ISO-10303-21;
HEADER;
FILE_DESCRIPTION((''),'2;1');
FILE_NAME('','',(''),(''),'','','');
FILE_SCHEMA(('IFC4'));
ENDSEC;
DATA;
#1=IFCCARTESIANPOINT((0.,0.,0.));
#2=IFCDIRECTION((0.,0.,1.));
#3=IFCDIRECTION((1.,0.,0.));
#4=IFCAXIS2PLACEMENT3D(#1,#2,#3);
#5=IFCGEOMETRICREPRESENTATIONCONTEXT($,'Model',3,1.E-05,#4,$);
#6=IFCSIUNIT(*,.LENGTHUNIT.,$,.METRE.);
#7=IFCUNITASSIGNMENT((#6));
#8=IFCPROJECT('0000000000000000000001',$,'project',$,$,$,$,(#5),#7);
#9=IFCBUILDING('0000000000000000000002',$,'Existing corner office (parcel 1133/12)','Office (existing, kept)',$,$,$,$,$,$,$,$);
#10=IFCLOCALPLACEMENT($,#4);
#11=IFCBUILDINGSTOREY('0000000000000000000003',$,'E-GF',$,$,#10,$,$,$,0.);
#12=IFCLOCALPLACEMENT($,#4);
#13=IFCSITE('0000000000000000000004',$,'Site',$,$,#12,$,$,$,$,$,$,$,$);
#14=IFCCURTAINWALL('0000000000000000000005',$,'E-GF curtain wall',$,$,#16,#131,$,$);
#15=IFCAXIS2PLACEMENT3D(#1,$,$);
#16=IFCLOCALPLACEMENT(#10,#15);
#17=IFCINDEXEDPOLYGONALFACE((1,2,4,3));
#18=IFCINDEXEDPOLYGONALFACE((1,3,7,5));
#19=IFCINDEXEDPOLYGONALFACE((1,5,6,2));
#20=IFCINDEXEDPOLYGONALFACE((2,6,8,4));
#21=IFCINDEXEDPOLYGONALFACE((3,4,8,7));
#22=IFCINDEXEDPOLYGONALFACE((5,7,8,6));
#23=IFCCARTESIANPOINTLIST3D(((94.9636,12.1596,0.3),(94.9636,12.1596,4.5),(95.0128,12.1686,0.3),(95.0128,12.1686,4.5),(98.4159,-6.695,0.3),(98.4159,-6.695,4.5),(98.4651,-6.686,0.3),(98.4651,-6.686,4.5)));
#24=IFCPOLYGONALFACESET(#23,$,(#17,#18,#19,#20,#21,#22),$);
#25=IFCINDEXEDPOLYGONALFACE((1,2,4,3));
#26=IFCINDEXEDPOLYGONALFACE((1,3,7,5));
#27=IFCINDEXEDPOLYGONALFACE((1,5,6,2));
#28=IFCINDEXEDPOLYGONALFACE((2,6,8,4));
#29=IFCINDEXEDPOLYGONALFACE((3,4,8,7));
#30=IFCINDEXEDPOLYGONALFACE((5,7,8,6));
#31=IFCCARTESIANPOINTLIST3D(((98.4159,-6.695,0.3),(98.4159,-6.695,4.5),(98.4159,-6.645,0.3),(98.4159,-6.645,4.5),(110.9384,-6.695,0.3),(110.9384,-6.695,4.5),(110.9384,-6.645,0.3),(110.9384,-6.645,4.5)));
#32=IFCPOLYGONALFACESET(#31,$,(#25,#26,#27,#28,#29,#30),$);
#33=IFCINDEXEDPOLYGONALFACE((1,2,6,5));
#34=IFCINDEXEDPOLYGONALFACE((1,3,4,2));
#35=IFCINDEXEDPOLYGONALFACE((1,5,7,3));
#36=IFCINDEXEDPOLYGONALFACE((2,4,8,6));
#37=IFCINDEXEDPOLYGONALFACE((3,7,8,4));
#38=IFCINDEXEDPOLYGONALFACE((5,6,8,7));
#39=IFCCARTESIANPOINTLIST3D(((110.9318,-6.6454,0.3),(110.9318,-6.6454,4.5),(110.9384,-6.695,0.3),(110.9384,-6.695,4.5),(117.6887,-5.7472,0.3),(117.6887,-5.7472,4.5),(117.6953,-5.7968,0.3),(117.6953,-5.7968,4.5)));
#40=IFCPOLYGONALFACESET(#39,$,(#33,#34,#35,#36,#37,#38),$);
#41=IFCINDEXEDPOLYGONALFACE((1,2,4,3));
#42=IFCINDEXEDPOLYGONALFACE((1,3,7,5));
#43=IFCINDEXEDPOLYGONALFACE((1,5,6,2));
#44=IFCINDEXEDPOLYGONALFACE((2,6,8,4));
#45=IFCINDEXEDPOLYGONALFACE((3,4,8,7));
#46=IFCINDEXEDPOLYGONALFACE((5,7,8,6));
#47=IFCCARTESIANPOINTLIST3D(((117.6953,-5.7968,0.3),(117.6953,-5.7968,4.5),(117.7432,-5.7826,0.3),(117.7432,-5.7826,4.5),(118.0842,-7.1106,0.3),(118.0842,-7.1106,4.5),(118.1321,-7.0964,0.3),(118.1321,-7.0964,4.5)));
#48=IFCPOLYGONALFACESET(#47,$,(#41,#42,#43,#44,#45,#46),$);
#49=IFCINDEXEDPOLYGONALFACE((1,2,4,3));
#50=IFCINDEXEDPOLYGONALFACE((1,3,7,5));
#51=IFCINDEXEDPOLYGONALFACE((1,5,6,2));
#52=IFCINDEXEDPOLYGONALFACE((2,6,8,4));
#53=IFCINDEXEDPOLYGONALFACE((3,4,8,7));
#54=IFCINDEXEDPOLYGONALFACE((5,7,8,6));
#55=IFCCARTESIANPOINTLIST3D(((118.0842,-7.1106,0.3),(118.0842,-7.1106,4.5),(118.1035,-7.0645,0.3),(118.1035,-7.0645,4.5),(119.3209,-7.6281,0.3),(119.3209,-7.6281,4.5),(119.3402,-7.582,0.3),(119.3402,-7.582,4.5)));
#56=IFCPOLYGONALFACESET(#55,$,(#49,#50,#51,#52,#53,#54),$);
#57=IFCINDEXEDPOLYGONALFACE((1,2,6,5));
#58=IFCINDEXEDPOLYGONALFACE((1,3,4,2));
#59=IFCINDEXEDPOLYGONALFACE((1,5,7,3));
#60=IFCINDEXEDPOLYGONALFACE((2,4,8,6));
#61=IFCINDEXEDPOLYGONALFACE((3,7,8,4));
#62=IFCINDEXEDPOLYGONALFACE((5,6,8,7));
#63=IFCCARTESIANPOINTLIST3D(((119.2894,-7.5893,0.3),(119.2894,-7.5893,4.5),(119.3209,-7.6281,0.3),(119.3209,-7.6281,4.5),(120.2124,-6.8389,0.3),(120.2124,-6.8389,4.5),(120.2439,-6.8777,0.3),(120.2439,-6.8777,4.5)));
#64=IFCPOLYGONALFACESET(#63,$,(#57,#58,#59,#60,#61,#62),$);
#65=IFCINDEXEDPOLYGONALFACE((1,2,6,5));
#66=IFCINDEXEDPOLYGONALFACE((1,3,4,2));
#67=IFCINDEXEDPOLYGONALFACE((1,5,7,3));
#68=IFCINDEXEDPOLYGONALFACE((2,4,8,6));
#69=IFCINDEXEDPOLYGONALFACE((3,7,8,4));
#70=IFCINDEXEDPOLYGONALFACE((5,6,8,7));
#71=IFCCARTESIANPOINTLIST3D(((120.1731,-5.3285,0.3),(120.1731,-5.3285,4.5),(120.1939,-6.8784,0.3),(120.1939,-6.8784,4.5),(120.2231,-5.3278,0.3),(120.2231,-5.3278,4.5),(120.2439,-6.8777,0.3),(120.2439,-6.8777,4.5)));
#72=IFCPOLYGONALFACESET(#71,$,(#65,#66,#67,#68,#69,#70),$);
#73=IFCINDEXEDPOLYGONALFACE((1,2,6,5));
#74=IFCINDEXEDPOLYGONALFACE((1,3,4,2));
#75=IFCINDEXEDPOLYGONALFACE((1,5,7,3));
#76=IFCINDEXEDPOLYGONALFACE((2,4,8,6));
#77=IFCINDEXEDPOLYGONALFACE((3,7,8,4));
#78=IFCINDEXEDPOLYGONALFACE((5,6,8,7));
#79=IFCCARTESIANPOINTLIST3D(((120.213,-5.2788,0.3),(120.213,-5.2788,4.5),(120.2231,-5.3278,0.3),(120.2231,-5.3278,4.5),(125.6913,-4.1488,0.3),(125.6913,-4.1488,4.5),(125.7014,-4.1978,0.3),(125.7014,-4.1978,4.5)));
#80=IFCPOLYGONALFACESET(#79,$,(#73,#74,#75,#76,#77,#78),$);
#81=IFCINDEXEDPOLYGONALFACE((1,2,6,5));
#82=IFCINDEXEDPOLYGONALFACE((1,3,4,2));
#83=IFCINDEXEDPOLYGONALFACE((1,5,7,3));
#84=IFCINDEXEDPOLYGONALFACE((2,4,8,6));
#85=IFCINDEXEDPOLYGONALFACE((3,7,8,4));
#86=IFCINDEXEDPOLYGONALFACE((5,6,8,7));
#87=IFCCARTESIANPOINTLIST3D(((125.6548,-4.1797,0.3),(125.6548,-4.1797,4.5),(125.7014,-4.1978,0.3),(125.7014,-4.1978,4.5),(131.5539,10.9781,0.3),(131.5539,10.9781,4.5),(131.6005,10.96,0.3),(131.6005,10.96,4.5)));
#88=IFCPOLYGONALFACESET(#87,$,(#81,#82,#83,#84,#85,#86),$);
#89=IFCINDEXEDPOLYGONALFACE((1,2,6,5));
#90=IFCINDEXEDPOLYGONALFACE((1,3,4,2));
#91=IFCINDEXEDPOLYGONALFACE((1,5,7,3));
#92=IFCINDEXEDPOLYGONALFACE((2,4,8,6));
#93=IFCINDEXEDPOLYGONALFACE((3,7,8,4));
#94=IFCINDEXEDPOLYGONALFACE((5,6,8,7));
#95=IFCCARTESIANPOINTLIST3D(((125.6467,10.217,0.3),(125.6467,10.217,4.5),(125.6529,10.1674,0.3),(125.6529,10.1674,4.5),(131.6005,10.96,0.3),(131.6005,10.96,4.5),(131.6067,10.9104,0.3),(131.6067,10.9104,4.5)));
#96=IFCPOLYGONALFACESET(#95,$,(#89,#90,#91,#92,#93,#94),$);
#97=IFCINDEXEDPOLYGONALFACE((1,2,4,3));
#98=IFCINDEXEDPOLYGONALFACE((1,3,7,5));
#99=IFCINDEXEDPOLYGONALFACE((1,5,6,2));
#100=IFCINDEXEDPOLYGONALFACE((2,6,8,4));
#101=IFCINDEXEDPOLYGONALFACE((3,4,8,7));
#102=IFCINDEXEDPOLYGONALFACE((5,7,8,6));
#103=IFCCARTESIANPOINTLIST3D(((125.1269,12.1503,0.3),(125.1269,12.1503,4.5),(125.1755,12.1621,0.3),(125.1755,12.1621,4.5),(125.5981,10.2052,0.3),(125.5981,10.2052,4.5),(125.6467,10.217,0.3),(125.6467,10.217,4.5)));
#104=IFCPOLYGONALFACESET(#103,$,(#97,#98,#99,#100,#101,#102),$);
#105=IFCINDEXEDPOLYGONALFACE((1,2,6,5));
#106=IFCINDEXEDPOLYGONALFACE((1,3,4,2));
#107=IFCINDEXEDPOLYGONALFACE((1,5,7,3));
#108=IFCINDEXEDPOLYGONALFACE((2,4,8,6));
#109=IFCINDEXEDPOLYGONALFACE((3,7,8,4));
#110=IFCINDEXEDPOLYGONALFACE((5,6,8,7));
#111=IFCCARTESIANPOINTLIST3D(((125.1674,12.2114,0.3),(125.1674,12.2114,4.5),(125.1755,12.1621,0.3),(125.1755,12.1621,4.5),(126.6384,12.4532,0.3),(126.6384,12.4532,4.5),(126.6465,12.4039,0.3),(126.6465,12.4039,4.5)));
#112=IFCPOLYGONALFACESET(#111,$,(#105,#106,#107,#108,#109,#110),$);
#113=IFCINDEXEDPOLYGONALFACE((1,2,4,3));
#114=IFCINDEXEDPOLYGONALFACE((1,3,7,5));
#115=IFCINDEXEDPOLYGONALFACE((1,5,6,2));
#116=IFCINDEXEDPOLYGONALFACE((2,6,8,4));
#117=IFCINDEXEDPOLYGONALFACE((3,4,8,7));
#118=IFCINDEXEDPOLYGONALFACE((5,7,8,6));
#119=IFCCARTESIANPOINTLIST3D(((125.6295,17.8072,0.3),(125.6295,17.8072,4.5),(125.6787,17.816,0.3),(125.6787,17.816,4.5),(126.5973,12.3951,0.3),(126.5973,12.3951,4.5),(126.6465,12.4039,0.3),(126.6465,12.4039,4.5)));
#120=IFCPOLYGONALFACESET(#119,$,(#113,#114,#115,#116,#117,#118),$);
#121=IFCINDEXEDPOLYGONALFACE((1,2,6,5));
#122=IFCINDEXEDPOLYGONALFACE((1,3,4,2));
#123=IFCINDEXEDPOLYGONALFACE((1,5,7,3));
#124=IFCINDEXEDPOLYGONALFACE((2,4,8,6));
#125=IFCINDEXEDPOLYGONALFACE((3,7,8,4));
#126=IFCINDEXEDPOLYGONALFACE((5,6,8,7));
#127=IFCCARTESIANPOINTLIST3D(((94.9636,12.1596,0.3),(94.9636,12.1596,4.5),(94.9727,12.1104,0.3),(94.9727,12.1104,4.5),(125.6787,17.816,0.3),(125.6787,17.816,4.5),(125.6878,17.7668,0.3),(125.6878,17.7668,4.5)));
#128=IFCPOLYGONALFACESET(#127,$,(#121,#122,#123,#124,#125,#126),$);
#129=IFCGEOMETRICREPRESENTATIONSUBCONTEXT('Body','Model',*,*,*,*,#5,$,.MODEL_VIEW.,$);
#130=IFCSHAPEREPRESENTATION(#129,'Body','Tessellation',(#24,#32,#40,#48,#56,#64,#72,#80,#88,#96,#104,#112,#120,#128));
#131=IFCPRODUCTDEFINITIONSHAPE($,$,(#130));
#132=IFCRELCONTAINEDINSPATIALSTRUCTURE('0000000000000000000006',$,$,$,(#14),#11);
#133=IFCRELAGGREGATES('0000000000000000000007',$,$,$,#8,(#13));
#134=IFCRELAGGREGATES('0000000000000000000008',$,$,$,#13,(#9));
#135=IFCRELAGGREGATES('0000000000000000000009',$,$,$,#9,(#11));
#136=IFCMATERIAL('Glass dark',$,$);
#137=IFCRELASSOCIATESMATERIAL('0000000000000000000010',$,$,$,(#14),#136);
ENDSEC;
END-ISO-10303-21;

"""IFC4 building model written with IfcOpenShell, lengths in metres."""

from ifc_helpers import new_model, si_unit, frame, origin_with_axes, place, context, subcontext, project, spatial, polyline, outline, extrude, material, element, save


model = new_model("IFC4")

# Units and contexts
model_context = context("Model", 3, precision=1e-05, world=origin_with_axes())
body_context = subcontext(model_context, "Body", "Model", "MODEL_VIEW")
ifc_project = project(units=[si_unit("LENGTHUNIT", "METRE")], contexts=[model_context])

# Site, building, storey
site_placement = place(None, origin_with_axes())
site = spatial("IfcSite", under=ifc_project, at=site_placement, Name="Site")
building = spatial("IfcBuilding", under=site, Name="Existing corner office (parcel 1133/12)", Description="Office (existing, kept)")
storey_placement = place(None, origin_with_axes())
storey = spatial("IfcBuildingStorey", under=building, at=storey_placement, Name="E-GF", Elevation=0.0)

# Curtain wall
ifc_material_1 = material(Name="Glass dark")
curtain_wall_placement = place(storey_placement, origin_with_axes())
element("IfcCurtainWall", 1, at=curtain_wall_placement, inside=storey, material=ifc_material_1, Name="E-GF curtain wall", context=body_context, shape_type="SweptSolid", body=[
    extrude(outline(polyline([(94.9636, 12.1596), (98.4159, -6.695), (98.4651, -6.686), (95.0128, 12.1686), (94.9636, 12.1596)])), frame((0.0, 0.0, 0.3), z_axis=(0.0, 0.0, 1.0), x_axis=(1.0, 0.0, 0.0)), (0.0, 0.0, 1.0), 4.2),
    extrude(outline(polyline([(98.4159, -6.695), (110.9384, -6.695), (110.9384, -6.645), (98.4159, -6.645), (98.4159, -6.695)])), frame((0.0, 0.0, 0.3), z_axis=(0.0, 0.0, 1.0), x_axis=(1.0, 0.0, 0.0)), (0.0, 0.0, 1.0), 4.2),
    extrude(outline(polyline([(110.9384, -6.695), (117.6953, -5.7968), (117.6887, -5.7472), (110.9318, -6.6454), (110.9384, -6.695)])), frame((0.0, 0.0, 0.3), z_axis=(0.0, 0.0, 1.0), x_axis=(1.0, 0.0, 0.0)), (0.0, 0.0, 1.0), 4.2),
    extrude(outline(polyline([(117.6953, -5.7968), (118.0842, -7.1106), (118.1321, -7.0964), (117.7432, -5.7826), (117.6953, -5.7968)])), frame((0.0, 0.0, 0.3), z_axis=(0.0, 0.0, 1.0), x_axis=(1.0, 0.0, 0.0)), (0.0, 0.0, 1.0), 4.2),
    extrude(outline(polyline([(118.0842, -7.1106), (119.3209, -7.6281), (119.3402, -7.582), (118.1035, -7.0645), (118.0842, -7.1106)])), frame((0.0, 0.0, 0.3), z_axis=(0.0, 0.0, 1.0), x_axis=(1.0, 0.0, 0.0)), (0.0, 0.0, 1.0), 4.2),
    extrude(outline(polyline([(119.3209, -7.6281), (120.2439, -6.8777), (120.2124, -6.8389), (119.2894, -7.5893), (119.3209, -7.6281)])), frame((0.0, 0.0, 0.3), z_axis=(0.0, 0.0, 1.0), x_axis=(1.0, 0.0, 0.0)), (0.0, 0.0, 1.0), 4.2),
    extrude(outline(polyline([(120.2439, -6.8777), (120.2231, -5.3278), (120.1731, -5.3285), (120.1939, -6.8784), (120.2439, -6.8777)])), frame((0.0, 0.0, 0.3), z_axis=(0.0, 0.0, 1.0), x_axis=(1.0, 0.0, 0.0)), (0.0, 0.0, 1.0), 4.2),
    extrude(outline(polyline([(120.2231, -5.3278), (125.7014, -4.1978), (125.6913, -4.1488), (120.213, -5.2788), (120.2231, -5.3278)])), frame((0.0, 0.0, 0.3), z_axis=(0.0, 0.0, 1.0), x_axis=(1.0, 0.0, 0.0)), (0.0, 0.0, 1.0), 4.2),
    extrude(outline(polyline([(125.7014, -4.1978), (131.6005, 10.96), (131.5539, 10.9781), (125.6548, -4.1797), (125.7014, -4.1978)])), frame((0.0, 0.0, 0.3), z_axis=(0.0, 0.0, 1.0), x_axis=(1.0, 0.0, 0.0)), (0.0, 0.0, 1.0), 4.2),
    extrude(outline(polyline([(131.6005, 10.96), (125.6467, 10.217), (125.6529, 10.1674), (131.6067, 10.9104), (131.6005, 10.96)])), frame((0.0, 0.0, 0.3), z_axis=(0.0, 0.0, 1.0), x_axis=(1.0, 0.0, 0.0)), (0.0, 0.0, 1.0), 4.2),
    extrude(outline(polyline([(125.6467, 10.217), (125.1755, 12.1621), (125.1269, 12.1503), (125.5981, 10.2052), (125.6467, 10.217)])), frame((0.0, 0.0, 0.3), z_axis=(0.0, 0.0, 1.0), x_axis=(1.0, 0.0, 0.0)), (0.0, 0.0, 1.0), 4.2),
    extrude(outline(polyline([(125.1755, 12.1621), (126.6465, 12.4039), (126.6384, 12.4532), (125.1674, 12.2114), (125.1755, 12.1621)])), frame((0.0, 0.0, 0.3), z_axis=(0.0, 0.0, 1.0), x_axis=(1.0, 0.0, 0.0)), (0.0, 0.0, 1.0), 4.2),
    extrude(outline(polyline([(126.6465, 12.4039), (125.6787, 17.816), (125.6295, 17.8072), (126.5973, 12.3951), (126.6465, 12.4039)])), frame((0.0, 0.0, 0.3), z_axis=(0.0, 0.0, 1.0), x_axis=(1.0, 0.0, 0.0)), (0.0, 0.0, 1.0), 4.2),
    extrude(outline(polyline([(125.6787, 17.816), (94.9636, 12.1596), (94.9727, 12.1104), (125.6878, 17.7668), (125.6787, 17.816)])), frame((0.0, 0.0, 0.3), z_axis=(0.0, 0.0, 1.0), x_axis=(1.0, 0.0, 0.0)), (0.0, 0.0, 1.0), 4.2),
])

save(model, "model.ifc")
